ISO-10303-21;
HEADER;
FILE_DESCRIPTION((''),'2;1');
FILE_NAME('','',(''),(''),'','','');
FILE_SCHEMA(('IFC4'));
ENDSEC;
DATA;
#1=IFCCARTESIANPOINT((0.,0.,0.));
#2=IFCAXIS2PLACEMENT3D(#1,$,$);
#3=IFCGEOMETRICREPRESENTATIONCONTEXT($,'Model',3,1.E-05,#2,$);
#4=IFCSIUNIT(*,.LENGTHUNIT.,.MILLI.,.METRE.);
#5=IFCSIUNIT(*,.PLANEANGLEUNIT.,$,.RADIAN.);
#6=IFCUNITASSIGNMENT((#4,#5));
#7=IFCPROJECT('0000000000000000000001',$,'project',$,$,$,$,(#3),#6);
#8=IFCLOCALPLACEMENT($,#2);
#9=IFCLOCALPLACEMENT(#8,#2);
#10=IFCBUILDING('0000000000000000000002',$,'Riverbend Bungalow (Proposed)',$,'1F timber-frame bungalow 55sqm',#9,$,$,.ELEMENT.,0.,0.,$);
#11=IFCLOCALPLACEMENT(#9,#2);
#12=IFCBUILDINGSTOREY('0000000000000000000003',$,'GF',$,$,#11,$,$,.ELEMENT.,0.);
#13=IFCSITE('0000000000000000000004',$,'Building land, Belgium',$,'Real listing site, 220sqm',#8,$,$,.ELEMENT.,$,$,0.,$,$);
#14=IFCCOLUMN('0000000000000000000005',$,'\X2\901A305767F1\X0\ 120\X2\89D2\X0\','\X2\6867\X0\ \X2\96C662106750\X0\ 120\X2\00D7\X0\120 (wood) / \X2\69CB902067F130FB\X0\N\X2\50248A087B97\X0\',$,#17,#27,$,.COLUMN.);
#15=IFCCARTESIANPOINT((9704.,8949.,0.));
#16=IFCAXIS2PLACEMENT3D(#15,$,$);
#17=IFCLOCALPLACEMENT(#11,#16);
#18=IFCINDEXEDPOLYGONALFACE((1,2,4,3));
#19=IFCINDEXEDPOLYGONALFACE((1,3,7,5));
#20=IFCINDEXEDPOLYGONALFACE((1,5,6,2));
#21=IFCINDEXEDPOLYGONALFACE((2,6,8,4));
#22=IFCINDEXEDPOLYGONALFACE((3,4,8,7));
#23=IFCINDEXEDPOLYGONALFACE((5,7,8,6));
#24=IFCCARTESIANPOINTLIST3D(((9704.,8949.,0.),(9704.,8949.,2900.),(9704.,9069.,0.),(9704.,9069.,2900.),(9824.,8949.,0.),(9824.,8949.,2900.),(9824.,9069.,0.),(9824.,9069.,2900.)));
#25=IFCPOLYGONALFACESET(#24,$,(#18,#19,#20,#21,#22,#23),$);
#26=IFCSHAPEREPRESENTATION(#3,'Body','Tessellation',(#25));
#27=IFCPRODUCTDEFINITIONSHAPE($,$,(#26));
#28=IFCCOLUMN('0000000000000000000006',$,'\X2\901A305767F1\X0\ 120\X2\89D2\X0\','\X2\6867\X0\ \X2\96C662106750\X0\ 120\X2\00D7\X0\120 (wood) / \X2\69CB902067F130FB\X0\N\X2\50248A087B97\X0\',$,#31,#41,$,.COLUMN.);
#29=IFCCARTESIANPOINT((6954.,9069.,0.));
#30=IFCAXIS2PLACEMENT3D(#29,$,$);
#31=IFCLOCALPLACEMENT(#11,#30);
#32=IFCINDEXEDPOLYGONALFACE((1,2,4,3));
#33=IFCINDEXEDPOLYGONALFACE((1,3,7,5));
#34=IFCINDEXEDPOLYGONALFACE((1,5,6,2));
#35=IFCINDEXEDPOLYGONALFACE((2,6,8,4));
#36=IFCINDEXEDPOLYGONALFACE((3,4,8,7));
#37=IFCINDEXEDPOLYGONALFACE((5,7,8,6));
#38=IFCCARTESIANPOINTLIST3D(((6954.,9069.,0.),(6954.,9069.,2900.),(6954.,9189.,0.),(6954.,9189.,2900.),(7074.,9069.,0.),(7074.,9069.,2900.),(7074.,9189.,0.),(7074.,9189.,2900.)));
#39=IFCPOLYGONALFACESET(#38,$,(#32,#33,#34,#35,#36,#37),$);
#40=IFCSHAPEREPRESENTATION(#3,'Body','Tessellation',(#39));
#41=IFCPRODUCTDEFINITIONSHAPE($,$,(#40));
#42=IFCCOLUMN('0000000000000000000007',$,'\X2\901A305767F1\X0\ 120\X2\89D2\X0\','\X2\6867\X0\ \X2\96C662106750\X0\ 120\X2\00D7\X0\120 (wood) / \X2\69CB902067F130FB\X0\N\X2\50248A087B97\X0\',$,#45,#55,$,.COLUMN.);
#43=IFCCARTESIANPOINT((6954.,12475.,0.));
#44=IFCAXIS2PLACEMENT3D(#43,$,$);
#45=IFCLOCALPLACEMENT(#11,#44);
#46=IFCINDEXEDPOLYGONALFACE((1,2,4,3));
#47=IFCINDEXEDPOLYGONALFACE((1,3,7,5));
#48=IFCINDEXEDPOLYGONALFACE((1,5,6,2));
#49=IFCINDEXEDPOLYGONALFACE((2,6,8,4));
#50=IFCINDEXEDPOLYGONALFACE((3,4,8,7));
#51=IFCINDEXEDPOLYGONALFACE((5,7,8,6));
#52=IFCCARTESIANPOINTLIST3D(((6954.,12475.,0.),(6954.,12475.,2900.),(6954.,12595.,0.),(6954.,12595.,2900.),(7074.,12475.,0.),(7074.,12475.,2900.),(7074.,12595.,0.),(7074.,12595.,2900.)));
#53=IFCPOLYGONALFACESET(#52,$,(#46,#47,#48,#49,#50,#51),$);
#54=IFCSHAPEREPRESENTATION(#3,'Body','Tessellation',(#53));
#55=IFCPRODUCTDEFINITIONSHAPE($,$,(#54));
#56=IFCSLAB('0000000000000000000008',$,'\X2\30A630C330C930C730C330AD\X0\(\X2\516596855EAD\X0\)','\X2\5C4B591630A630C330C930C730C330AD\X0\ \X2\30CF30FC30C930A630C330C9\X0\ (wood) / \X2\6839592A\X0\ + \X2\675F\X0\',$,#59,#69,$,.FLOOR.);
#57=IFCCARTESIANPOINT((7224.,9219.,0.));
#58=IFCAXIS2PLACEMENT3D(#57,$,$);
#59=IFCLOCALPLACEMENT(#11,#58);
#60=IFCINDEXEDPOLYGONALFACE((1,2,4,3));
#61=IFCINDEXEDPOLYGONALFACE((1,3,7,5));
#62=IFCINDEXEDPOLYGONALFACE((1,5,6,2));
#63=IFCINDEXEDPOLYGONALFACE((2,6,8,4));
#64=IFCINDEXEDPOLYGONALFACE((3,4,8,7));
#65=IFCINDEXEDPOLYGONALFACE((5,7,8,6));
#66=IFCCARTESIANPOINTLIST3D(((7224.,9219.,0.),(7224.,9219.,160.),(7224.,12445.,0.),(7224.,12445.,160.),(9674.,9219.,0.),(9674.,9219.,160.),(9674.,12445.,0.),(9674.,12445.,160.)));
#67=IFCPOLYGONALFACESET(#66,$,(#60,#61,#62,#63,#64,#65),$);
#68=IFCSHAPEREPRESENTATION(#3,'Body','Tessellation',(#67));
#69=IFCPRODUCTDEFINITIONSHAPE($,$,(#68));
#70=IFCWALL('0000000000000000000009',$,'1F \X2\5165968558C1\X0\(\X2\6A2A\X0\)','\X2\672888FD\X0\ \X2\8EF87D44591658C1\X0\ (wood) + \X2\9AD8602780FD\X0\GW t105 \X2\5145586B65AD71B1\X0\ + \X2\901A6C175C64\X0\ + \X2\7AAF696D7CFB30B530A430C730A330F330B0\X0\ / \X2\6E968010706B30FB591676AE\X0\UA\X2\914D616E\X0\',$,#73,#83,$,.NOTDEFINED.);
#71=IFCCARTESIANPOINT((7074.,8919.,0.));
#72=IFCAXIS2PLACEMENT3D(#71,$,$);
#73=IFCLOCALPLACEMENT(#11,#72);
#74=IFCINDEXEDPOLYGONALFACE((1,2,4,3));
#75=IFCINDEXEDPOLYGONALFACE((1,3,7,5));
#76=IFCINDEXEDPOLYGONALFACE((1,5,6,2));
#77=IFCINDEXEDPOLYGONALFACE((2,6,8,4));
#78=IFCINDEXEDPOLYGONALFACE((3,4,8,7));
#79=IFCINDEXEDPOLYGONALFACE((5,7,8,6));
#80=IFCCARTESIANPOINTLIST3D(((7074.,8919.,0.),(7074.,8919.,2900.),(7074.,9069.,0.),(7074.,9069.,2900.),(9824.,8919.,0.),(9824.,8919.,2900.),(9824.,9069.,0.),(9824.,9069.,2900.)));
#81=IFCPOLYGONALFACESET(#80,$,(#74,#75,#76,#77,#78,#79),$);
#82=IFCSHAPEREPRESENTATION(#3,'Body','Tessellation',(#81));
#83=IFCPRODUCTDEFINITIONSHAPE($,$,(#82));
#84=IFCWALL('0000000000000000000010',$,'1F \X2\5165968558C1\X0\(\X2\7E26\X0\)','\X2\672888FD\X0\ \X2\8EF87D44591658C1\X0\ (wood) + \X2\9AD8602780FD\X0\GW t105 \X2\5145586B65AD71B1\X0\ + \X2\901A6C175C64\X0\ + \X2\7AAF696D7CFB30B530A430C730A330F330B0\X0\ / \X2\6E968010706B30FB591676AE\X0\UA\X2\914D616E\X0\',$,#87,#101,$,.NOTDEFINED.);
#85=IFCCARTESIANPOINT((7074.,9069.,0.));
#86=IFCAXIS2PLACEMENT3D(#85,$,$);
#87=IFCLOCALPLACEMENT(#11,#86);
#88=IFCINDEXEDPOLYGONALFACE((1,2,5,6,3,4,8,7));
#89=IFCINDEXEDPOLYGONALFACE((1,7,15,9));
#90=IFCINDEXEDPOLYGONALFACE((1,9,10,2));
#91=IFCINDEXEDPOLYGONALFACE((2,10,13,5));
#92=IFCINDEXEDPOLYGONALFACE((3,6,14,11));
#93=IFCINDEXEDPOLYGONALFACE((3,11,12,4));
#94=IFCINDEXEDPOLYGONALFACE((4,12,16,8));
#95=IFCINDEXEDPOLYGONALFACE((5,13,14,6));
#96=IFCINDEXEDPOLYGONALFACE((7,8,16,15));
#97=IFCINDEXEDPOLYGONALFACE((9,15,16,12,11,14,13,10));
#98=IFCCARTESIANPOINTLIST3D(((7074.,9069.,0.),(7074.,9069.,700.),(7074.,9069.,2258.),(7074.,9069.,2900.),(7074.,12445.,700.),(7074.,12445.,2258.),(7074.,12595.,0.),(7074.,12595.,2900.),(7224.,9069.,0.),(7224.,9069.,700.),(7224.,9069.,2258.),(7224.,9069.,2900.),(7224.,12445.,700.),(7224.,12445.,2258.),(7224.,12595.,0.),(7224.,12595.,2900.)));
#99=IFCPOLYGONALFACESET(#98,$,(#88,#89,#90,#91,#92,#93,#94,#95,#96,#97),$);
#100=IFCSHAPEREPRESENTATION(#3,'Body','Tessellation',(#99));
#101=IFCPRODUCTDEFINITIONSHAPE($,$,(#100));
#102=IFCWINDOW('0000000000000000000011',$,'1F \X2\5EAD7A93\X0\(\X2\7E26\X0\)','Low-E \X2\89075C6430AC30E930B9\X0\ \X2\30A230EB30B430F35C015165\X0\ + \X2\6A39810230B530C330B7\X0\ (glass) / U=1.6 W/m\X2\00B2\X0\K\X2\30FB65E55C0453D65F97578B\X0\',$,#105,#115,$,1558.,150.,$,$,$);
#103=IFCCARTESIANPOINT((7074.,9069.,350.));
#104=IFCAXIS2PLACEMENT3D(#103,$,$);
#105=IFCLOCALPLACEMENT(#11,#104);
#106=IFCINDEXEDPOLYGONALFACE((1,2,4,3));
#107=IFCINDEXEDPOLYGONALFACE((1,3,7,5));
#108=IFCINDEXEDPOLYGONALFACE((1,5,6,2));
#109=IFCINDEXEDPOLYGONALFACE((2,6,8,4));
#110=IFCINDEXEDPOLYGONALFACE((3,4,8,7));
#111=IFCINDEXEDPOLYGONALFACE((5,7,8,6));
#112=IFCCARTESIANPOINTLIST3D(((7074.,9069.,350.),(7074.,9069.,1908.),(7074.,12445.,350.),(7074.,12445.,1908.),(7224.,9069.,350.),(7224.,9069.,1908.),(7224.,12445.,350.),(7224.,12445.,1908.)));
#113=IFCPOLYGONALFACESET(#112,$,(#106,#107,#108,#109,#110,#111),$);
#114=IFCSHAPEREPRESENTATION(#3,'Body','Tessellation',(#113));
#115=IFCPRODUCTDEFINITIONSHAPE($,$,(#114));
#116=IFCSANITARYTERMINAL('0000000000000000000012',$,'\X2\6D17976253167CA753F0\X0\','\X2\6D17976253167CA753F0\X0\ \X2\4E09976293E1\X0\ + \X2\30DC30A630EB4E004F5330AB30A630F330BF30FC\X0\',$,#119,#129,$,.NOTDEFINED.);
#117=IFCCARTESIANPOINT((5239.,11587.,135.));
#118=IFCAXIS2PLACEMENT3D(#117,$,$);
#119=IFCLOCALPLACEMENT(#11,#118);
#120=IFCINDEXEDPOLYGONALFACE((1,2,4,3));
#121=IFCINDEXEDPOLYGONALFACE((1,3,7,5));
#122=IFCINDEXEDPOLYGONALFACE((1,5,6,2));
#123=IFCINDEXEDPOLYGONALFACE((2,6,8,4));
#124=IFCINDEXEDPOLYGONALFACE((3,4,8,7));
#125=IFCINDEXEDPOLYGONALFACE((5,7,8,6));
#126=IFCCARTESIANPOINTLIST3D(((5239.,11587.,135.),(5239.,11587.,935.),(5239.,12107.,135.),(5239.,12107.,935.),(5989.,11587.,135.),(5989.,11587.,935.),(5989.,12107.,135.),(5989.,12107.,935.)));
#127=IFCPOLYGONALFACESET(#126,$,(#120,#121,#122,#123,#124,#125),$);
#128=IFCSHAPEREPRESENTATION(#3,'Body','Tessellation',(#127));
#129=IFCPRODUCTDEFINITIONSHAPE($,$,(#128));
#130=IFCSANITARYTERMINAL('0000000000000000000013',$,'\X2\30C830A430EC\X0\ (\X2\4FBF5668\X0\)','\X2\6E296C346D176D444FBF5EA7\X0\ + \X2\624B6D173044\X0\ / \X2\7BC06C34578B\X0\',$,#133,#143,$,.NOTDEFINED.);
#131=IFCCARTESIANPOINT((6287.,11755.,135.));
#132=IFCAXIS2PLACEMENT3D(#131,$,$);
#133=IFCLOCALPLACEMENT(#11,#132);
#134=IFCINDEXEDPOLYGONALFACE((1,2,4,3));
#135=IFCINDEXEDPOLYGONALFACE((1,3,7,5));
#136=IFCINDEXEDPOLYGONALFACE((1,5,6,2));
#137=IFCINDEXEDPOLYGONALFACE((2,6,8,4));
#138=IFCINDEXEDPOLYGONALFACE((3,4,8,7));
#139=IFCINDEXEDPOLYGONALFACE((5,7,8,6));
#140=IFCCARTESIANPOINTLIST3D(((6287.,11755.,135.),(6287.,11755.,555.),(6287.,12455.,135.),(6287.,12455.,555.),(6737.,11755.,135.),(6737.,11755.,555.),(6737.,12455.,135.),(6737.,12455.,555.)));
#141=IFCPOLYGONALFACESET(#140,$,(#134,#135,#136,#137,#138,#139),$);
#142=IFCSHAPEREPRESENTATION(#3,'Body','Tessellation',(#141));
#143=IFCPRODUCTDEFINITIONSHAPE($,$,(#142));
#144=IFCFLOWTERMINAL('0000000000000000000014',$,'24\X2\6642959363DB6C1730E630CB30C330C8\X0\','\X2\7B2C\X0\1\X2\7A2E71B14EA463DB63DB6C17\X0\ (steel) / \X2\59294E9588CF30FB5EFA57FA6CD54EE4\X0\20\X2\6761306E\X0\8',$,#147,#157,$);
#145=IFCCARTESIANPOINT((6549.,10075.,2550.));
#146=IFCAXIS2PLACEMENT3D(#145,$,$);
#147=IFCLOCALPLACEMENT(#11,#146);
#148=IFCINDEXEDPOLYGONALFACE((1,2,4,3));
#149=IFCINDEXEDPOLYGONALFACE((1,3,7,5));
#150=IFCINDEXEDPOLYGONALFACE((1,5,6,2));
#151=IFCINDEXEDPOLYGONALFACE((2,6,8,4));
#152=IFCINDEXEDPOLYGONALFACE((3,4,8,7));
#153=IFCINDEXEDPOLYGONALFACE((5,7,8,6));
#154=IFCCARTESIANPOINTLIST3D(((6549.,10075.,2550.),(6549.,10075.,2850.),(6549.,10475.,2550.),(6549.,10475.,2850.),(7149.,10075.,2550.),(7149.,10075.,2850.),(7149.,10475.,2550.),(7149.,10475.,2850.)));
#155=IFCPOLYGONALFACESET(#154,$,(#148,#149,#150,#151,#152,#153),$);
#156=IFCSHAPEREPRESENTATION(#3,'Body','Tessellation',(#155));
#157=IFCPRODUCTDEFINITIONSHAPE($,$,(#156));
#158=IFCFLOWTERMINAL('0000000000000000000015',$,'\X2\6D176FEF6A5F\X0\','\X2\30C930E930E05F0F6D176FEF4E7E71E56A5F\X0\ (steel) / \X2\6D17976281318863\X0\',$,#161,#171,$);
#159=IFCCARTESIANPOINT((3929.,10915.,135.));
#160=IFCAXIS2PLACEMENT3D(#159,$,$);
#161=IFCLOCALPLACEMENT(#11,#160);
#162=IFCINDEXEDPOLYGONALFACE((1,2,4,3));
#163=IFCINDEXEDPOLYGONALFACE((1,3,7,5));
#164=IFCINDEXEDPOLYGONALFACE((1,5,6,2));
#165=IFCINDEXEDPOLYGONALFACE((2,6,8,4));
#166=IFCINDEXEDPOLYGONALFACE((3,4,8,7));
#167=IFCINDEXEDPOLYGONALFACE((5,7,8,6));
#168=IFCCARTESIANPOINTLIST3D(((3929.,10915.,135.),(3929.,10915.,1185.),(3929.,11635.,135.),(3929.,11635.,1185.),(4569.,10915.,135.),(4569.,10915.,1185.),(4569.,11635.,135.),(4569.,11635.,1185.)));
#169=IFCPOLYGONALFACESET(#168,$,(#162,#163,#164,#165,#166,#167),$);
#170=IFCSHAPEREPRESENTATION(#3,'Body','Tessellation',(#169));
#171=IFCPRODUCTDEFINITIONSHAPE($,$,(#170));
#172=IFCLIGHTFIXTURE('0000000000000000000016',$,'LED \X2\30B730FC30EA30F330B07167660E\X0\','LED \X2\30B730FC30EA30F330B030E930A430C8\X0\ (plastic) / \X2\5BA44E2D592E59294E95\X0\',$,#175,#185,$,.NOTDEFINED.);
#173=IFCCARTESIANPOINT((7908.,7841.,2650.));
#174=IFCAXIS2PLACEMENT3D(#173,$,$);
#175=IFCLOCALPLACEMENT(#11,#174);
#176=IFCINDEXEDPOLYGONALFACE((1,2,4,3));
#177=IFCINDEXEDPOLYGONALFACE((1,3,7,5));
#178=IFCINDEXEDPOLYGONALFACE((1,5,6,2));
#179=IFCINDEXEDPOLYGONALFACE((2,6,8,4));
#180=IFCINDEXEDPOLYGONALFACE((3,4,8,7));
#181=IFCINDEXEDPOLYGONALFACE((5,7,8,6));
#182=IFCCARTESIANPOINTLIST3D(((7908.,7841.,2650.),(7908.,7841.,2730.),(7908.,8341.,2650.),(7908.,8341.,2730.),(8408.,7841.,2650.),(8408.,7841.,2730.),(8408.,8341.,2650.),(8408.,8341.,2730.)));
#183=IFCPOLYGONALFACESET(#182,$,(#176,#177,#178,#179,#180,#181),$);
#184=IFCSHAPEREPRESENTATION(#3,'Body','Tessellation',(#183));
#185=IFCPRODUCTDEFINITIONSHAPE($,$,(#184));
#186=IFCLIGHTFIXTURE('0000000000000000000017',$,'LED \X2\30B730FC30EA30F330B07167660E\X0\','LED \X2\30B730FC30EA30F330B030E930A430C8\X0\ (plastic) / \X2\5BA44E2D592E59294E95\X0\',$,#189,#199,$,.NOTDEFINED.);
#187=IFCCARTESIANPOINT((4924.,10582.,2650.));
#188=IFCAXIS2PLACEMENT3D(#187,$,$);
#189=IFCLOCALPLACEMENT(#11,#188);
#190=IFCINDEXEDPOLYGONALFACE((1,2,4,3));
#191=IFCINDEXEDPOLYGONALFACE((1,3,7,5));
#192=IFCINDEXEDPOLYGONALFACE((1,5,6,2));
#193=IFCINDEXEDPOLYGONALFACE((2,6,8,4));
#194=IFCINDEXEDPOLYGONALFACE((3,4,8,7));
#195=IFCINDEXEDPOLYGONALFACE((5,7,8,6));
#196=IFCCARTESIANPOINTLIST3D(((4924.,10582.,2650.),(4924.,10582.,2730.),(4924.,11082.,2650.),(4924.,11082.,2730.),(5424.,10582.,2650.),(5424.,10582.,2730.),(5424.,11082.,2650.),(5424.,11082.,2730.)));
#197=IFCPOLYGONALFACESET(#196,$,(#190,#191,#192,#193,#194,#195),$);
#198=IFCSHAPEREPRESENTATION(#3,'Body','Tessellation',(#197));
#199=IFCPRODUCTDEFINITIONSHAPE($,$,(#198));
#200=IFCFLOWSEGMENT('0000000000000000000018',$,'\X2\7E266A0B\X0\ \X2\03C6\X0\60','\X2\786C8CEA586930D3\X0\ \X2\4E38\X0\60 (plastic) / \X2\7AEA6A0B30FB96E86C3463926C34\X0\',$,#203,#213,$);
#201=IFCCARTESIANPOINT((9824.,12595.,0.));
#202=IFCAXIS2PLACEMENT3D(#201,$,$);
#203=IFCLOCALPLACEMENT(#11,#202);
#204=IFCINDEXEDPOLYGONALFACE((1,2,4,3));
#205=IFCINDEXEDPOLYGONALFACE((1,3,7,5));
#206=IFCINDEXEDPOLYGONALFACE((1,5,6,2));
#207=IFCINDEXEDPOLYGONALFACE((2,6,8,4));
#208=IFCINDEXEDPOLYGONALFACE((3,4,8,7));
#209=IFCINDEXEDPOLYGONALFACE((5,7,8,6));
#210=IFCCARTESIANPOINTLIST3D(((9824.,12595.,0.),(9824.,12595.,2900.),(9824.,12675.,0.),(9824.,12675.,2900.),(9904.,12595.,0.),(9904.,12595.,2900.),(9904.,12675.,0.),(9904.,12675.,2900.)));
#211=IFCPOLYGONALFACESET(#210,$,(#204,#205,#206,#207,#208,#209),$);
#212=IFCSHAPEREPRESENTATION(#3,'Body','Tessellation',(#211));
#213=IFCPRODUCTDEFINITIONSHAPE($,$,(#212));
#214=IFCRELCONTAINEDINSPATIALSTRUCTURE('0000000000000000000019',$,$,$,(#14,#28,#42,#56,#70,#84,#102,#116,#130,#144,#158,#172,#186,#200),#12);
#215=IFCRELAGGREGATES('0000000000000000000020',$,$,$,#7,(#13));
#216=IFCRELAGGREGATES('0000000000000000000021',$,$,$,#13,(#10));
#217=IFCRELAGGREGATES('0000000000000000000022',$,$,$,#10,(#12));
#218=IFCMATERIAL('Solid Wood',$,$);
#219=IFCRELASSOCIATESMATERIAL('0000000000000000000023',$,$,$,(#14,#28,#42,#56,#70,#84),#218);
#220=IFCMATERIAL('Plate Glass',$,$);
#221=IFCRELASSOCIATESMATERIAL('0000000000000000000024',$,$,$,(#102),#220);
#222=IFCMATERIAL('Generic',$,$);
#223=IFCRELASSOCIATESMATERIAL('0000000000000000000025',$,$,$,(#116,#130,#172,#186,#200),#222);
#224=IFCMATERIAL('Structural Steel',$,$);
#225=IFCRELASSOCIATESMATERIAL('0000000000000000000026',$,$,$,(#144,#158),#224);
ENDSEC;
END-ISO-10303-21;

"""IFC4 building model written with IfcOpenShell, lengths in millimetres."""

from ifc_helpers import new_model, si_unit, frame, frame_2d, origin, place, context, project, spatial, rectangle, extrude, material, element, fill, save


model = new_model("IFC4")

# Units and contexts
model_context = context("Model", 3, precision=1e-05, world=origin())
ifc_project = project(units=[si_unit("LENGTHUNIT", "METRE", prefix="MILLI"), si_unit("PLANEANGLEUNIT", "RADIAN")], contexts=[model_context])

# Site, building, storey
site_placement = place(None, origin())
site = spatial("IfcSite", under=ifc_project, at=site_placement, Name="Building land, Belgium", ObjectType="Real listing site, 220sqm", CompositionType="ELEMENT", RefElevation=0.0)
building_placement = place(site_placement, origin())
building = spatial("IfcBuilding", under=site, at=building_placement, Name="Riverbend Bungalow (Proposed)", ObjectType="1F timber-frame bungalow 55sqm", CompositionType="ELEMENT", ElevationOfRefHeight=0.0, ElevationOfTerrain=0.0)
storey_placement = place(building_placement, origin())
storey = spatial("IfcBuildingStorey", under=building, at=storey_placement, Name="GF", CompositionType="ELEMENT", Elevation=0.0)

# Columns
ifc_material_1 = material(Name="Solid Wood")
column_1_placement = place(storey_placement, frame((9704.0, 8949.0, 0.0)))
element("IfcColumn", 1, at=column_1_placement, inside=storey, material=ifc_material_1, Name="通し柱 120角", Description="桧 集成材 120×120 (wood) / 構造柱・N値計算", PredefinedType="COLUMN", context=model_context, shape_type="SweptSolid", body=[
    extrude(rectangle(XDim=120.0, YDim=120.0, at=frame_2d((60.0, 60.0))), frame((9704.0, 8949.0, 0.0)), (0.0, 0.0, 1.0), 2900.0),
])
column_2_placement = place(storey_placement, frame((6954.0, 9069.0, 0.0)))
element("IfcColumn", 2, at=column_2_placement, inside=storey, material=ifc_material_1, Name="通し柱 120角", Description="桧 集成材 120×120 (wood) / 構造柱・N値計算", PredefinedType="COLUMN", context=model_context, shape_type="SweptSolid", body=[
    extrude(rectangle(XDim=120.0, YDim=120.0, at=frame_2d((60.0, 60.0))), frame((6954.0, 9069.0, 0.0)), (0.0, 0.0, 1.0), 2900.0),
])
column_3_placement = place(storey_placement, frame((6954.0, 12475.0, 0.0)))
element("IfcColumn", 3, at=column_3_placement, inside=storey, material=ifc_material_1, Name="通し柱 120角", Description="桧 集成材 120×120 (wood) / 構造柱・N値計算", PredefinedType="COLUMN", context=model_context, shape_type="SweptSolid", body=[
    extrude(rectangle(XDim=120.0, YDim=120.0, at=frame_2d((60.0, 60.0))), frame((6954.0, 12475.0, 0.0)), (0.0, 0.0, 1.0), 2900.0),
])

# Slab
slab_placement = place(storey_placement, frame((7224.0, 9219.0, 0.0)))
element("IfcSlab", 4, at=slab_placement, inside=storey, material=ifc_material_1, Name="ウッドデッキ(入隅庭)", Description="屋外ウッドデッキ ハードウッド (wood) / 根太 + 束", PredefinedType="FLOOR", context=model_context, shape_type="SweptSolid", body=[
    extrude(rectangle(XDim=2450.0, YDim=3226.0, at=frame_2d((1225.0, 1613.0))), frame((7224.0, 9219.0, 0.0)), (0.0, 0.0, 1.0), 160.0),
])

# Wall
wall_1_placement = place(storey_placement, frame((7074.0, 8919.0, 0.0)))
element("IfcWall", 5, at=wall_1_placement, inside=storey, material=ifc_material_1, Name="1F 入隅壁(横)", Description="木製 軸組外壁 (wood) + 高性能GW t105 充填断熱 + 通気層 + 窯業系サイディング / 準耐火・外皮UA配慮", PredefinedType="NOTDEFINED", context=model_context, shape_type="SweptSolid", body=[
    extrude(rectangle(XDim=2750.0, YDim=150.0, at=frame_2d((1375.0, 75.0))), frame((7074.0, 8919.0, 0.0)), (0.0, 0.0, 1.0), 2900.0),
])

# Wall, opening, window
wall_2_placement = place(storey_placement, frame((7074.0, 9069.0, 0.0)))
wall_2 = element("IfcWall", 6, at=wall_2_placement, inside=storey, material=ifc_material_1, Name="1F 入隅壁(縦)", Description="木製 軸組外壁 (wood) + 高性能GW t105 充填断熱 + 通気層 + 窯業系サイディング / 準耐火・外皮UA配慮", PredefinedType="NOTDEFINED", context=model_context, shape_type="SweptSolid", body=[
    extrude(rectangle(XDim=150.0, YDim=3526.0, at=frame_2d((75.0, 1763.0))), frame((7074.0, 9069.0, 0.0)), (0.0, 0.0, 1.0), 2900.0),
])
opening_placement = place(storey_placement, frame((7074.0, 9069.0, 350.0)))
opening = element("IfcOpeningElement", 7, at=opening_placement, cuts=wall_2, PredefinedType="NOTDEFINED", context=model_context, shape_type="SweptSolid", body=[
    extrude(rectangle(XDim=150.0, YDim=3376.0, at=frame_2d((75.0, 1688.0))), frame((7074.0, 9069.0, 350.0)), (0.0, 0.0, 1.0), 1558.0),
])
ifc_material_2 = material(Name="Plate Glass")
window_placement = place(storey_placement, frame((7074.0, 9069.0, 350.0)))
window = element("IfcWindow", 8, at=window_placement, inside=storey, material=ifc_material_2, Name="1F 庭窓(縦)", Description="Low-E 複層ガラス アルゴン封入 + 樹脂サッシ (glass) / U=1.6 W/m²K・日射取得型", OverallHeight=1558.0, OverallWidth=150.0, context=model_context, shape_type="SweptSolid", body=[
    extrude(rectangle(XDim=150.0, YDim=3376.0, at=frame_2d((75.0, 1688.0))), frame((7074.0, 9069.0, 350.0)), (0.0, 0.0, 1.0), 1558.0),
])
fill(opening, window)

# Sanitary terminals
ifc_material_3 = material(Name="Generic")
sanitary_terminal_1_placement = place(storey_placement, frame((5239.0, 11587.0, 135.0)))
element("IfcSanitaryTerminal", 9, at=sanitary_terminal_1_placement, inside=storey, material=ifc_material_3, Name="洗面化粧台", Description="洗面化粧台 三面鏡 + ボウル一体カウンター", PredefinedType="NOTDEFINED", context=model_context, shape_type="SweptSolid", body=[
    extrude(rectangle(XDim=750.0, YDim=520.0, at=frame_2d((375.0, 260.0))), frame((5239.0, 11587.0, 135.0)), (0.0, 0.0, 1.0), 800.0),
])
sanitary_terminal_2_placement = place(storey_placement, frame((6287.0, 11755.0, 135.0)))
element("IfcSanitaryTerminal", 10, at=sanitary_terminal_2_placement, inside=storey, material=ifc_material_3, Name="トイレ (便器)", Description="温水洗浄便座 + 手洗い / 節水型", PredefinedType="NOTDEFINED", context=model_context, shape_type="SweptSolid", body=[
    extrude(rectangle(XDim=450.0, YDim=700.0, at=frame_2d((225.0, 350.0))), frame((6287.0, 11755.0, 135.0)), (0.0, 0.0, 1.0), 420.0),
])

# Flow terminals
ifc_material_4 = material(Name="Structural Steel")
flow_terminal_1_placement = place(storey_placement, frame((6549.0, 10075.0, 2550.0)))
element("IfcFlowTerminal", 11, at=flow_terminal_1_placement, inside=storey, material=ifc_material_4, Name="24時間換気ユニット", Description="第1種熱交換換気 (steel) / 天井裏・建基法令20条の8", context=model_context, shape_type="SweptSolid", body=[
    extrude(rectangle(XDim=600.0, YDim=400.0, at=frame_2d((300.0, 200.0))), frame((6549.0, 10075.0, 2550.0)), (0.0, 0.0, 1.0), 300.0),
])
flow_terminal_2_placement = place(storey_placement, frame((3929.0, 10915.0, 135.0)))
element("IfcFlowTerminal", 12, at=flow_terminal_2_placement, inside=storey, material=ifc_material_4, Name="洗濯機", Description="ドラム式洗濯乾燥機 (steel) / 洗面脱衣", context=model_context, shape_type="SweptSolid", body=[
    extrude(rectangle(XDim=640.0, YDim=720.0, at=frame_2d((320.0, 360.0))), frame((3929.0, 10915.0, 135.0)), (0.0, 0.0, 1.0), 1050.0),
])

# Light fixtures
light_fixture_1_placement = place(storey_placement, frame((7908.0, 7841.0, 2650.0)))
element("IfcLightFixture", 13, at=light_fixture_1_placement, inside=storey, material=ifc_material_3, Name="LED シーリング照明", Description="LED シーリングライト (plastic) / 室中央天井", PredefinedType="NOTDEFINED", context=model_context, shape_type="SweptSolid", body=[
    extrude(rectangle(XDim=500.0, YDim=500.0, at=frame_2d((250.0, 250.0))), frame((7908.0, 7841.0, 2650.0)), (0.0, 0.0, 1.0), 80.0),
])
light_fixture_2_placement = place(storey_placement, frame((4924.0, 10582.0, 2650.0)))
element("IfcLightFixture", 14, at=light_fixture_2_placement, inside=storey, material=ifc_material_3, Name="LED シーリング照明", Description="LED シーリングライト (plastic) / 室中央天井", PredefinedType="NOTDEFINED", context=model_context, shape_type="SweptSolid", body=[
    extrude(rectangle(XDim=500.0, YDim=500.0, at=frame_2d((250.0, 250.0))), frame((4924.0, 10582.0, 2650.0)), (0.0, 0.0, 1.0), 80.0),
])

# Flow segment
flow_segment_placement = place(storey_placement, frame((9824.0, 12595.0, 0.0)))
element("IfcFlowSegment", 15, at=flow_segment_placement, inside=storey, material=ifc_material_3, Name="縦樋 φ60", Description="硬質塩ビ 丸60 (plastic) / 竪樋・雨水排水", context=model_context, shape_type="SweptSolid", body=[
    extrude(rectangle(XDim=80.0, YDim=80.0, at=frame_2d((40.0, 40.0))), frame((9824.0, 12595.0, 0.0)), (0.0, 0.0, 1.0), 2900.0),
])

save(model, "model.ifc")
